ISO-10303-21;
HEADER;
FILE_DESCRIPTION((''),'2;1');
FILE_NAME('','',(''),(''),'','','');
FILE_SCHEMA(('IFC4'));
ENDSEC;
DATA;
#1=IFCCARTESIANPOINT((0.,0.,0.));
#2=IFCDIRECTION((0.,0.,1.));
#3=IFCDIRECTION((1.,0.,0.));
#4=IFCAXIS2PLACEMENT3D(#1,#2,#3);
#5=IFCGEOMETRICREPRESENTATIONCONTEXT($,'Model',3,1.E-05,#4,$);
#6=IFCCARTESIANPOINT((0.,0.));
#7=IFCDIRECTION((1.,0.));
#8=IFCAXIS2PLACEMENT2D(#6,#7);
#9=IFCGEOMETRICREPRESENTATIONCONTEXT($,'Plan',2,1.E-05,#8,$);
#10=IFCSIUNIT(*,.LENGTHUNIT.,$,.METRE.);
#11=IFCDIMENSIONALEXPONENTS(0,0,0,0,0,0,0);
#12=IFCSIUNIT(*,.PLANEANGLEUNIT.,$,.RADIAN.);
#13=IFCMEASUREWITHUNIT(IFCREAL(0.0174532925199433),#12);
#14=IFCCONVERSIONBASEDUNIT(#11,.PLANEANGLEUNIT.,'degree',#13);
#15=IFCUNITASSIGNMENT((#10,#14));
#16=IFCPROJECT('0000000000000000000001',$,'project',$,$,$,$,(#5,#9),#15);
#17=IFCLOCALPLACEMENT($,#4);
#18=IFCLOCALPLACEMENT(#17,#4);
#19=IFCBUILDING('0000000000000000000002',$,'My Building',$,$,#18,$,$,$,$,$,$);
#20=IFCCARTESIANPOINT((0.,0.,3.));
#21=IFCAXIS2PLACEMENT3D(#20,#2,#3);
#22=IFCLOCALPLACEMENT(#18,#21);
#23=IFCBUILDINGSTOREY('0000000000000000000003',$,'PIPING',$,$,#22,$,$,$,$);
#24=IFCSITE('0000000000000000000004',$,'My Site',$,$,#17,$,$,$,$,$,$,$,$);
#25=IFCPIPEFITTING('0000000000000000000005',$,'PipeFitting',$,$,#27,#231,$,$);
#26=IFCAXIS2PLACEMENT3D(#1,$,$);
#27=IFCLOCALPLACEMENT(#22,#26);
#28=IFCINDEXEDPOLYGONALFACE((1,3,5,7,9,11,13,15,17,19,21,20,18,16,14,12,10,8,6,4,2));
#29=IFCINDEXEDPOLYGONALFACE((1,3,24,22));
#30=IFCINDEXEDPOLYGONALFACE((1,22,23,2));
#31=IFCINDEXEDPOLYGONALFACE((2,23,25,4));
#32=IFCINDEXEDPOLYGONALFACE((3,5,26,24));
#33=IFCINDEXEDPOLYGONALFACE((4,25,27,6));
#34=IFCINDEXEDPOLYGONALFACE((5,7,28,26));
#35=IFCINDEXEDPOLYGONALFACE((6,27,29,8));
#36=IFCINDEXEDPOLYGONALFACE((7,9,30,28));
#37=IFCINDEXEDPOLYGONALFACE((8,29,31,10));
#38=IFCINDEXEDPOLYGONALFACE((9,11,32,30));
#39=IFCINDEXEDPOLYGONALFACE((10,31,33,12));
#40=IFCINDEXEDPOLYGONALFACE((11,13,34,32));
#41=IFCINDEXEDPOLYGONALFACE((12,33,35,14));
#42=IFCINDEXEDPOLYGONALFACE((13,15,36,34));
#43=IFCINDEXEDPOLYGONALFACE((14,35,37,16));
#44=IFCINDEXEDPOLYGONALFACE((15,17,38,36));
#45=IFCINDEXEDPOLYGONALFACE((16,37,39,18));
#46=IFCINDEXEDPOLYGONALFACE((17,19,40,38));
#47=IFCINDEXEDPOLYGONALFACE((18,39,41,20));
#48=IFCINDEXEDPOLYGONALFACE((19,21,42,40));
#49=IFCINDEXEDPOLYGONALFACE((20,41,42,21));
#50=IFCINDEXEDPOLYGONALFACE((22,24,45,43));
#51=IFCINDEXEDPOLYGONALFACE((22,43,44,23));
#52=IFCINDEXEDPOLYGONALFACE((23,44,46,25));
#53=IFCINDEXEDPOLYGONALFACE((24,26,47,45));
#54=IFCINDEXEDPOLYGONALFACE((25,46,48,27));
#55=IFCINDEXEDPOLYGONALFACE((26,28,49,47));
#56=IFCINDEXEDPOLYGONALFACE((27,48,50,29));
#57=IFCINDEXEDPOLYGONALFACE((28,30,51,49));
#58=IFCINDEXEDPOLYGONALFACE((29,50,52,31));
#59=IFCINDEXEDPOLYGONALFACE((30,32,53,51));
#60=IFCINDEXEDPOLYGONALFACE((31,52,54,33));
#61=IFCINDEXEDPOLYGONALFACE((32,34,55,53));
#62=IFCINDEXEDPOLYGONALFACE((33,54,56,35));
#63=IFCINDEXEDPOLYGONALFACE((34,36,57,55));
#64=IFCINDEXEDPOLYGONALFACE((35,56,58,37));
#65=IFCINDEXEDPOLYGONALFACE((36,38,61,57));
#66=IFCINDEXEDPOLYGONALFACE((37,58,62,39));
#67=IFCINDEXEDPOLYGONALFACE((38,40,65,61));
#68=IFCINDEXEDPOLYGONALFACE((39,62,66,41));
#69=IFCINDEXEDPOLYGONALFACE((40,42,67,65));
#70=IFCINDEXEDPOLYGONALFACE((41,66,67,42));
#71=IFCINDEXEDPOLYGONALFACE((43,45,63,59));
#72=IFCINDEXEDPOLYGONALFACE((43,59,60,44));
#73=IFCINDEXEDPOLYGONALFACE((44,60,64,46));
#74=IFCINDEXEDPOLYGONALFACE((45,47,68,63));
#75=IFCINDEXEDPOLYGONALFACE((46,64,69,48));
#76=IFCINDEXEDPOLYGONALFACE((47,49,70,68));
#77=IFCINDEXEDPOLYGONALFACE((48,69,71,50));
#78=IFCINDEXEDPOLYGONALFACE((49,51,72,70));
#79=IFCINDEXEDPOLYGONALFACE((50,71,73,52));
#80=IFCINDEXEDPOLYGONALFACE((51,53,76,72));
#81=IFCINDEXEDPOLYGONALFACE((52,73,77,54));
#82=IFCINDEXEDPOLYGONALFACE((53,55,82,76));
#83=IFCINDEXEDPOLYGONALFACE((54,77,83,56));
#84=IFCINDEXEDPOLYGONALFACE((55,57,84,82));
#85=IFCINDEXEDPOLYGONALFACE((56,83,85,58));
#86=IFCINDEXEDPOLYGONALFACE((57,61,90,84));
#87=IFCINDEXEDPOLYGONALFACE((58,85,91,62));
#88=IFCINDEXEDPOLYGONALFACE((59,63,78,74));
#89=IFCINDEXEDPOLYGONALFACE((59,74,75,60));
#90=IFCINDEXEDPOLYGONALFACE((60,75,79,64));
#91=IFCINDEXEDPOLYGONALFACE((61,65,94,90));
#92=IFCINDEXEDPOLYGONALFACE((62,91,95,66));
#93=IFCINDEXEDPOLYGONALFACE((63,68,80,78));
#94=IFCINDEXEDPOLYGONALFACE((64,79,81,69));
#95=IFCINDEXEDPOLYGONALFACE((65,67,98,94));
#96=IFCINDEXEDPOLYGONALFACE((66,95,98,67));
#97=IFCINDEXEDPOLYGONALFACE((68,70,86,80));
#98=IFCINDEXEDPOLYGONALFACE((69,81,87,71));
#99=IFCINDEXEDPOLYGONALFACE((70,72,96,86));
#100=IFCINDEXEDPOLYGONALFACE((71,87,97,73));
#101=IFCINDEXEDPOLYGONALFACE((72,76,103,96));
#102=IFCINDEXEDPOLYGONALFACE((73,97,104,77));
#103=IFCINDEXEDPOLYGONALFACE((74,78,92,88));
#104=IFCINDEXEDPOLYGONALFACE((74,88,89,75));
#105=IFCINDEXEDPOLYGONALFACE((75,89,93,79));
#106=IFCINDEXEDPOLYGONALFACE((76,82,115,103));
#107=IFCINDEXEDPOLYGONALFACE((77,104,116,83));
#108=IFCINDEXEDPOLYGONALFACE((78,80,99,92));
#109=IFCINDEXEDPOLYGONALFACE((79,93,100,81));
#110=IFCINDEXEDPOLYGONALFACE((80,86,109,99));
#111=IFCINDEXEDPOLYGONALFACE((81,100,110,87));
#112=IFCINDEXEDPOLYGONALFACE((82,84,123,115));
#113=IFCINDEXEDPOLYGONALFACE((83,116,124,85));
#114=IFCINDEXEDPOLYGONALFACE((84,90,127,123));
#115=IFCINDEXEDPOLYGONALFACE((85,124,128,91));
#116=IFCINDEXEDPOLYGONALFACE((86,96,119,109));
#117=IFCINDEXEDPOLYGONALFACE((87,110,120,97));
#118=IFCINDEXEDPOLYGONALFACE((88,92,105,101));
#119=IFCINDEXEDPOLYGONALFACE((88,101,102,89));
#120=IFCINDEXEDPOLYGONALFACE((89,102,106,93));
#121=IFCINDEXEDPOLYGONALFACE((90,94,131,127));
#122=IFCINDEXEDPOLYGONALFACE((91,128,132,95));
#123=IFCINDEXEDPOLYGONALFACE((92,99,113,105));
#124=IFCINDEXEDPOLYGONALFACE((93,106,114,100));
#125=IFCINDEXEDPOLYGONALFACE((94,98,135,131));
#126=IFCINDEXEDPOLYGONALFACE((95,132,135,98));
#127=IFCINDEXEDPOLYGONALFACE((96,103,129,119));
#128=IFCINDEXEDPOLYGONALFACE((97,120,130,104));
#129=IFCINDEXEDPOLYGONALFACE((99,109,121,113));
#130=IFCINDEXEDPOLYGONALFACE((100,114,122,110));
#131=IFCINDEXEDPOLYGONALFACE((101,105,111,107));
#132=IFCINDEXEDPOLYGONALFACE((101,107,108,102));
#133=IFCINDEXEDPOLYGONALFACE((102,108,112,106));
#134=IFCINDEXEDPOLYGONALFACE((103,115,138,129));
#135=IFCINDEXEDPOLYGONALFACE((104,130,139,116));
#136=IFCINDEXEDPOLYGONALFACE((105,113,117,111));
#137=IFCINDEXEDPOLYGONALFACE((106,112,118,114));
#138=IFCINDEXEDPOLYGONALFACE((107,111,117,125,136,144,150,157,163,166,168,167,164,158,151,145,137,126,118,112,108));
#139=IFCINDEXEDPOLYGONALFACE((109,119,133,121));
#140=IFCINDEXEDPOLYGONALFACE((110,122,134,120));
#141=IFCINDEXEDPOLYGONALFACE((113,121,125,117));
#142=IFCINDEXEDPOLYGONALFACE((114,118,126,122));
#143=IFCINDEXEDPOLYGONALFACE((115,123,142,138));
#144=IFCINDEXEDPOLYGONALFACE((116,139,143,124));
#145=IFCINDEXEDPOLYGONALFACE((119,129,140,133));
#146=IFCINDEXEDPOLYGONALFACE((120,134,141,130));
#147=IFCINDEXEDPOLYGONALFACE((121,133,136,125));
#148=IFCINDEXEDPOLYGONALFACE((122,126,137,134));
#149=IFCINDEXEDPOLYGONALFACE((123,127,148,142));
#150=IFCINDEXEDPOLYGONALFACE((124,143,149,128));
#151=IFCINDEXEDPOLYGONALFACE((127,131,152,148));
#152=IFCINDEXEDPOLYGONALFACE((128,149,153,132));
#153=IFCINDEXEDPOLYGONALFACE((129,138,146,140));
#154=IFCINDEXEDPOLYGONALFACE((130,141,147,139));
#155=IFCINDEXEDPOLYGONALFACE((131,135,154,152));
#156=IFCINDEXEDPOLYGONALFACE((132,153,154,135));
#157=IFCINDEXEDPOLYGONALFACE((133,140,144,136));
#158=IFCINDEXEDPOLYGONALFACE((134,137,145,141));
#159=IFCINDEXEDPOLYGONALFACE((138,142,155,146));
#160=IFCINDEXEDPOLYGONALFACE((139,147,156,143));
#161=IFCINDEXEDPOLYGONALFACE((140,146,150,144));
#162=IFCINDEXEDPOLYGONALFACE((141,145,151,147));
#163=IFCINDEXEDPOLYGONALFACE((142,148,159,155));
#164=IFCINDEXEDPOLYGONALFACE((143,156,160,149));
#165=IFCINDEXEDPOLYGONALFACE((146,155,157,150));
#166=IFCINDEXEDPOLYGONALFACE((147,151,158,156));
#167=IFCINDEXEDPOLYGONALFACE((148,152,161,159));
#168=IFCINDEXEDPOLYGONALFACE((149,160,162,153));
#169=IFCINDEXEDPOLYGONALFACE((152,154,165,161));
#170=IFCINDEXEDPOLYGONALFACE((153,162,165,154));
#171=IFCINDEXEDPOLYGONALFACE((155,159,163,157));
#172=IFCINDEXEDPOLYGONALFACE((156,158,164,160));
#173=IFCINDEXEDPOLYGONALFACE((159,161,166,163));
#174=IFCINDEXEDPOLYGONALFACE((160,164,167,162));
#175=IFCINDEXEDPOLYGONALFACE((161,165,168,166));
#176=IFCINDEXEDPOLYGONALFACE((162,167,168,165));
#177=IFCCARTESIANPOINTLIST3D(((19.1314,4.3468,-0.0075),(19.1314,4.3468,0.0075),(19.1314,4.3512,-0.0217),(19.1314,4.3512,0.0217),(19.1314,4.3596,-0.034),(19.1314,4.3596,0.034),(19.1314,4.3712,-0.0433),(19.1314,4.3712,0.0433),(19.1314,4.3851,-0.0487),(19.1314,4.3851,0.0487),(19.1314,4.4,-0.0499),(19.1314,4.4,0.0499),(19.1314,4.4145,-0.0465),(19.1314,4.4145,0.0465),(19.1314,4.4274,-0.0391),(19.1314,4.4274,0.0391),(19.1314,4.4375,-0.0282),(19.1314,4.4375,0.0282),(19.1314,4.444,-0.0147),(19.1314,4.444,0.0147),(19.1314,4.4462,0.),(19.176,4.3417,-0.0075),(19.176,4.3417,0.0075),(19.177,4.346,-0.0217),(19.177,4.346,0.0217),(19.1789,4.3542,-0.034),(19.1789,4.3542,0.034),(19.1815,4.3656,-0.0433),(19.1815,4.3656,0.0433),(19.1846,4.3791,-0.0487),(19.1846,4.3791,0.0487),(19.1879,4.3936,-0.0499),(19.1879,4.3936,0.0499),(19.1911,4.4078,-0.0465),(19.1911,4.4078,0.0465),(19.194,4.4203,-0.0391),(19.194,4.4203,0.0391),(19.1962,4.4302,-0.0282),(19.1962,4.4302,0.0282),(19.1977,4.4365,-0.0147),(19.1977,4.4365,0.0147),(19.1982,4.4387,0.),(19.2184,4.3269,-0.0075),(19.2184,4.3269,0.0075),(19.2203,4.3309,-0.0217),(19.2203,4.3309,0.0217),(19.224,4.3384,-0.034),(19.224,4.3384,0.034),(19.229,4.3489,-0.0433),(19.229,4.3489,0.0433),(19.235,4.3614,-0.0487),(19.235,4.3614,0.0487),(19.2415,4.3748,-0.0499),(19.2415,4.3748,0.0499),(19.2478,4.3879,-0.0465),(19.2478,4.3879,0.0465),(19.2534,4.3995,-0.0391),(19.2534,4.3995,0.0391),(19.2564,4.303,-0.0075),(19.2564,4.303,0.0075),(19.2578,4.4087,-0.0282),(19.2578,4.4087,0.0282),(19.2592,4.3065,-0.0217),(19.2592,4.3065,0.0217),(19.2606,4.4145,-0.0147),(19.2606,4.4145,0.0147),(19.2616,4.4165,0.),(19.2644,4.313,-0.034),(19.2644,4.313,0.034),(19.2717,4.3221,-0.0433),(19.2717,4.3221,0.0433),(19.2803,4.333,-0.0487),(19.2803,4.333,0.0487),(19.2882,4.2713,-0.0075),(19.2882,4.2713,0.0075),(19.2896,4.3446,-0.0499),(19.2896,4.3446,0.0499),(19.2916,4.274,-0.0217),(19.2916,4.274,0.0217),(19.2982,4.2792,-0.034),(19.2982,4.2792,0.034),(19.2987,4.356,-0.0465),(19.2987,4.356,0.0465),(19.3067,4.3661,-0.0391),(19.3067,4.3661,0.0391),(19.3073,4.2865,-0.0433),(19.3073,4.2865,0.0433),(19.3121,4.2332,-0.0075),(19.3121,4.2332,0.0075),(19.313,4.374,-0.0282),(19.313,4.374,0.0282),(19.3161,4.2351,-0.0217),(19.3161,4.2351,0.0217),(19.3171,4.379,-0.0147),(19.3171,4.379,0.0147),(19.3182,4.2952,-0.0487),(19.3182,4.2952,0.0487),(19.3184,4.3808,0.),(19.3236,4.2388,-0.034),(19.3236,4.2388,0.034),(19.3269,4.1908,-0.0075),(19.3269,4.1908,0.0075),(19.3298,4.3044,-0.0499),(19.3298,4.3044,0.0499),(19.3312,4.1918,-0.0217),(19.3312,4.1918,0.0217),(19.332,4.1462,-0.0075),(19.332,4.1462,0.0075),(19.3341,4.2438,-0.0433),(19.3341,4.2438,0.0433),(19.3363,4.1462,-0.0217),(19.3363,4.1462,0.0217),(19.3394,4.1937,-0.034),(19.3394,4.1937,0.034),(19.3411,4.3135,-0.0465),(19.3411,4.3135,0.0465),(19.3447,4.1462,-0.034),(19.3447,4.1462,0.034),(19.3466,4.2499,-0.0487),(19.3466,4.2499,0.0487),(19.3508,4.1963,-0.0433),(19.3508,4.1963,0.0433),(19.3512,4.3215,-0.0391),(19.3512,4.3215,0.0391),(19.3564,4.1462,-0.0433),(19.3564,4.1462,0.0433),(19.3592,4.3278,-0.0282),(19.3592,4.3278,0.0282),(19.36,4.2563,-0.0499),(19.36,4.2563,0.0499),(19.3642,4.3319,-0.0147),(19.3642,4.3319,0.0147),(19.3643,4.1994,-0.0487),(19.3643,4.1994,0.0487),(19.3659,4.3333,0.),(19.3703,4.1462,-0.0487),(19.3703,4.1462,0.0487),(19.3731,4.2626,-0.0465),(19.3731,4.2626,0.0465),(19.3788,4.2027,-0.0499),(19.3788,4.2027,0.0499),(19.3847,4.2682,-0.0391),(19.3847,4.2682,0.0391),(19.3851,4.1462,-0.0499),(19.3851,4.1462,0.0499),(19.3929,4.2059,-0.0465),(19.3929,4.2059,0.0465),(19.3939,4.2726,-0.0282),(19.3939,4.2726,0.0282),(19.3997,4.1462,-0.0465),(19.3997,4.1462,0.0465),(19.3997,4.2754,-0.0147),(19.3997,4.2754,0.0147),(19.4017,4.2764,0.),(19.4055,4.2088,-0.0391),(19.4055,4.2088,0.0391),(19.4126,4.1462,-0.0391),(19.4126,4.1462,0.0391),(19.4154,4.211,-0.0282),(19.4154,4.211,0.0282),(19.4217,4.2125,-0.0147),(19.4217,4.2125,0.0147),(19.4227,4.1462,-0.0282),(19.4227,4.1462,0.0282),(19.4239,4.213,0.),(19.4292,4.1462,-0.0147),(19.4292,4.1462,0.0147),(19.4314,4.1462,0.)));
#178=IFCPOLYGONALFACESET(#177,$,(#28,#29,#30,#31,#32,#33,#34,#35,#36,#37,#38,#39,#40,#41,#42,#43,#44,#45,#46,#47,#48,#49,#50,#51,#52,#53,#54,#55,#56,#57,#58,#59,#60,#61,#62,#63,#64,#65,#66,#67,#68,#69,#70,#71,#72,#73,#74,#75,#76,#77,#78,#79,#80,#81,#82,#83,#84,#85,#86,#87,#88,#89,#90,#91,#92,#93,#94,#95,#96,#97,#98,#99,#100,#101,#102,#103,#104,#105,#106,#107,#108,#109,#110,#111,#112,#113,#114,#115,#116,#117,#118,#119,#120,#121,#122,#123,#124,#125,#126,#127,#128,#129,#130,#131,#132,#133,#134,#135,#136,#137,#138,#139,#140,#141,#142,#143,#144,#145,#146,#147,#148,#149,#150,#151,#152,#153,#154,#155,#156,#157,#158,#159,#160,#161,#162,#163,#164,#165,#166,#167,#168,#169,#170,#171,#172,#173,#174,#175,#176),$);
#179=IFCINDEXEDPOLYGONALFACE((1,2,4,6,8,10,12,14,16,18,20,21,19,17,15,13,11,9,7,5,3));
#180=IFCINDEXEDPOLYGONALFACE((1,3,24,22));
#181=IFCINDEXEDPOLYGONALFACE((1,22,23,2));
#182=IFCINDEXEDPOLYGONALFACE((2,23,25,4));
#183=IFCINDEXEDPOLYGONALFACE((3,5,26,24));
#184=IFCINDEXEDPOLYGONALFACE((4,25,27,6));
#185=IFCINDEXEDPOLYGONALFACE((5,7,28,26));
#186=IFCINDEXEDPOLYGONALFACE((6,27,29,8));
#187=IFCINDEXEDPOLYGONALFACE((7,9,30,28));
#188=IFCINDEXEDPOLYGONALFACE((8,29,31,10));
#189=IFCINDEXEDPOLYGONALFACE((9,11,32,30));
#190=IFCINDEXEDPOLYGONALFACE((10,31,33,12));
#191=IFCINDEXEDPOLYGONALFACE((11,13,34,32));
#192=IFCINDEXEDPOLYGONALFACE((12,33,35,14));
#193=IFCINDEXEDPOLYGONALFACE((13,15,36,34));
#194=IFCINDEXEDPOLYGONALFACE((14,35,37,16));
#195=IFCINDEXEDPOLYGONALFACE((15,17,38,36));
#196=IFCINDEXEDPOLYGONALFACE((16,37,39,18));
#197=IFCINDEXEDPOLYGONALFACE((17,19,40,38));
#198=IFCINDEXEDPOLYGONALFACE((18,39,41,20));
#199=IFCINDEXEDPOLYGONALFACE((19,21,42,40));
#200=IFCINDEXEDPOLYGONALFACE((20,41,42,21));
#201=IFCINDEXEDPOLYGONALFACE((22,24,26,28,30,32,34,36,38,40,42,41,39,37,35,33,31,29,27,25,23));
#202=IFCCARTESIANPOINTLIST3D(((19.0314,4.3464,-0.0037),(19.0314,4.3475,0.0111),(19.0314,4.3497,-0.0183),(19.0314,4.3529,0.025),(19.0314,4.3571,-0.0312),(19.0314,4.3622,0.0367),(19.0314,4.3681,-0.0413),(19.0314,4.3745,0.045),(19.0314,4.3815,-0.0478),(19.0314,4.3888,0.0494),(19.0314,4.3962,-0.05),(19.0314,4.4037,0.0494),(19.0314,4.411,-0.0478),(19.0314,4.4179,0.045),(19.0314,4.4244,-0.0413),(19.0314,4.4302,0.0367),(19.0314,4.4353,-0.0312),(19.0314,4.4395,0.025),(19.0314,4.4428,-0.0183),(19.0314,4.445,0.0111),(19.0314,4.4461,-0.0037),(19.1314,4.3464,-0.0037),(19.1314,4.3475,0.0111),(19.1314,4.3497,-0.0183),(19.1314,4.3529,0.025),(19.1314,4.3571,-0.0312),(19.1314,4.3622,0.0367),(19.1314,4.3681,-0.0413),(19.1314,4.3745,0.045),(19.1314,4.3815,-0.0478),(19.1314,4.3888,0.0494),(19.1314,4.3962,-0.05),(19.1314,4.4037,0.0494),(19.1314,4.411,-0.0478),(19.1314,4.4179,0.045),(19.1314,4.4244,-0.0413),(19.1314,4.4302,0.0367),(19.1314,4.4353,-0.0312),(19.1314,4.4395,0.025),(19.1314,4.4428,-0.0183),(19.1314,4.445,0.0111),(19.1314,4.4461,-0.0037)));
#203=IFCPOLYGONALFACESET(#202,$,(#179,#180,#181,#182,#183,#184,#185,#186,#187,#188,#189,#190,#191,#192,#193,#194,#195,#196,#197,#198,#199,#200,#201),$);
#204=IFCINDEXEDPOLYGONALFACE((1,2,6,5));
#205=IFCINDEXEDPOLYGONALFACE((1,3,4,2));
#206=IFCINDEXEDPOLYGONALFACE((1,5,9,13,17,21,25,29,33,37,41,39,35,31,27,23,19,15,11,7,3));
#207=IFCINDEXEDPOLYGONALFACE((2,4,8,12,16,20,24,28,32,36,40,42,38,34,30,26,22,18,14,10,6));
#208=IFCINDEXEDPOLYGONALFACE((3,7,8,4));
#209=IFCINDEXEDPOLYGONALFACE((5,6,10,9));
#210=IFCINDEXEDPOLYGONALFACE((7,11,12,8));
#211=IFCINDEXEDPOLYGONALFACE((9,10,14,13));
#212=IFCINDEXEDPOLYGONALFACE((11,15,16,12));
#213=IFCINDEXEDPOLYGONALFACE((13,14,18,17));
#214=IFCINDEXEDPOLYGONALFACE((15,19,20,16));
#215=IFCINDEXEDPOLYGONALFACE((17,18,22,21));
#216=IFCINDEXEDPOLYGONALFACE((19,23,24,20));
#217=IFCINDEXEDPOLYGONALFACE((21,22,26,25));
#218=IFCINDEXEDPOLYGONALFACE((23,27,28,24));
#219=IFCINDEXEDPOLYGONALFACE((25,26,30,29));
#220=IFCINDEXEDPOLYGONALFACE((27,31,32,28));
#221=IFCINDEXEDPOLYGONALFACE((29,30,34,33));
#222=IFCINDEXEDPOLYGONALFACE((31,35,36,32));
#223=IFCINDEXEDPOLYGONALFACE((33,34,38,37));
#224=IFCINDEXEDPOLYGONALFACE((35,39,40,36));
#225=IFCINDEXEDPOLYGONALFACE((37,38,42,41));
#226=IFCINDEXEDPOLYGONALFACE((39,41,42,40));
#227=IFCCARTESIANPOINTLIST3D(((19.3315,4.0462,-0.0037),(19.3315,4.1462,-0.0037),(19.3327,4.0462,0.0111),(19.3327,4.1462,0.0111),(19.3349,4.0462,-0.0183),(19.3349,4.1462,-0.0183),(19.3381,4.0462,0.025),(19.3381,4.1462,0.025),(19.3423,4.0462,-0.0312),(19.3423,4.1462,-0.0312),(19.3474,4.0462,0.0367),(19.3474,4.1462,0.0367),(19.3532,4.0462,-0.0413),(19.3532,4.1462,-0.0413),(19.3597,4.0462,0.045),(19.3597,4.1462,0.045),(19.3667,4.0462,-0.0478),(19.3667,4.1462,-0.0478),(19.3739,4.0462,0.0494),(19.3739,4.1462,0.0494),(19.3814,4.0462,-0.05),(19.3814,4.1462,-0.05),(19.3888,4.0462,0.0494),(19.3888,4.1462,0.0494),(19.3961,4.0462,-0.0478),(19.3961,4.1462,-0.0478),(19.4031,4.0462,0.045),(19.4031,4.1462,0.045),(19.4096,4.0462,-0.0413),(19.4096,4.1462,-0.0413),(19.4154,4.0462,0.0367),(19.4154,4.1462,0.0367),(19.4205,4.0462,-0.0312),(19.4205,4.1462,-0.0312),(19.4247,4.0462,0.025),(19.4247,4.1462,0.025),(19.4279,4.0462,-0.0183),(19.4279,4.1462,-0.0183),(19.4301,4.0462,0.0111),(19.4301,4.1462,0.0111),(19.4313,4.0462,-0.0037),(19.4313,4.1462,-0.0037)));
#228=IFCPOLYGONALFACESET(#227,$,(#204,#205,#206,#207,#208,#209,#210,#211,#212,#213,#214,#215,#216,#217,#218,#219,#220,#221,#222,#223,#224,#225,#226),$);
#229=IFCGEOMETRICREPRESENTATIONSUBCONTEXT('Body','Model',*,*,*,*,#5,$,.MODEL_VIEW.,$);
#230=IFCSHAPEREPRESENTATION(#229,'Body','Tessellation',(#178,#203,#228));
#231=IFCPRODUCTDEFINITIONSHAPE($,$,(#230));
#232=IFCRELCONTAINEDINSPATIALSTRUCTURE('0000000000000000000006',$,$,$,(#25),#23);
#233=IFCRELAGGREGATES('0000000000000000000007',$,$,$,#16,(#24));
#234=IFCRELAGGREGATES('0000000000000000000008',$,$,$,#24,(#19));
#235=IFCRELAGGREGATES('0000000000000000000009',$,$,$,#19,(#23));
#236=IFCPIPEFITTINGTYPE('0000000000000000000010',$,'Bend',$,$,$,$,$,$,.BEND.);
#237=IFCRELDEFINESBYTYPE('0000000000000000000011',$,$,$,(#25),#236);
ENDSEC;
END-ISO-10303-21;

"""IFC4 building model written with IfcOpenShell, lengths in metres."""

from ifc_helpers import new_model, entity, si_unit, converted_unit, frame, origin_with_axes, origin_2d_with_axis, place, context, subcontext, project, spatial, circle, extrude, source, transform, mapped, type_object, type_shapes, element, save


model = new_model("IFC4")

# Units and contexts
model_context = context("Model", 3, precision=1e-05, world=origin_with_axes())
plan_context = context("Plan", 2, precision=1e-05, world=origin_2d_with_axis())
body_context = subcontext(model_context, "Body", "Model", "MODEL_VIEW")
ifc_project = project(units=[si_unit("LENGTHUNIT", "METRE"), converted_unit("PLANEANGLEUNIT", "degree", entity("IfcReal", 0.0174532925199433), si_unit("PLANEANGLEUNIT", "RADIAN"), dimensions=[0, 0, 0, 0, 0, 0, 0])], contexts=[model_context, plan_context])

# Site, building, storey
site_placement = place(None, origin_with_axes())
site = spatial("IfcSite", under=ifc_project, at=site_placement, Name="My Site")
building_placement = place(site_placement, origin_with_axes())
building = spatial("IfcBuilding", under=site, at=building_placement, Name="My Building")
storey_placement = place(building_placement, frame((0.0, 0.0, 3.0), z_axis=(0.0, 0.0, 1.0), x_axis=(1.0, 0.0, 0.0)))
storey = spatial("IfcBuildingStorey", under=building, at=storey_placement, Name="PIPING")

# Shared definitions
pipe_fitting_type = type_object("IfcPipeFittingType", Name="Bend", PredefinedType="BEND")
shared_shape = source(origin_with_axes(), body_context, "Body", "SolidModel", [
    entity("IfcSweptDiskSolid", entity("IfcIndexedPolyCurve", entity("IfcCartesianPointList3D", [[0.0, 0.0, -0.1], [0.0, 0.0732, -0.2768], [0.0, 0.25, -0.35]]), [entity("IfcArcIndex", [1, 2, 3])]), 0.05),
    extrude(circle(Radius=0.05), origin_with_axes(), (0.0, 0.0, -1.0), 0.1),
    extrude(circle(Radius=0.05), frame((0.0, 0.25, -0.35), z_axis=(0.0, 1.0, 0.0), x_axis=(1.0, 0.0, 0.0)), (0.0, 0.0, 1.0), 0.1),
])
type_shapes(pipe_fitting_type, [shared_shape])

# Pipe fitting
for number, where, z_axis, x_axis, name in (
    (1, (19.0314, 4.3962, 0.0), (-1.0, 0.0, 0.0), (0.0, 0.0, -1.0), "PipeFitting"),
):
    element("IfcPipeFitting", number, at=place(storey_placement, frame(where, z_axis=z_axis, x_axis=x_axis)), inside=storey, type_object=pipe_fitting_type, Name=name, context=body_context, shape_type="MappedRepresentation", body=[
        mapped(shared_shape, transform((0.0, 0.0, 0.0), x_axis=(1.0, 0.0, 0.0), y_axis=(0.0, 1.0, 0.0), z_axis=(0.0, 0.0, 1.0), scale=1.0)),
    ])

save(model, "model.ifc")
